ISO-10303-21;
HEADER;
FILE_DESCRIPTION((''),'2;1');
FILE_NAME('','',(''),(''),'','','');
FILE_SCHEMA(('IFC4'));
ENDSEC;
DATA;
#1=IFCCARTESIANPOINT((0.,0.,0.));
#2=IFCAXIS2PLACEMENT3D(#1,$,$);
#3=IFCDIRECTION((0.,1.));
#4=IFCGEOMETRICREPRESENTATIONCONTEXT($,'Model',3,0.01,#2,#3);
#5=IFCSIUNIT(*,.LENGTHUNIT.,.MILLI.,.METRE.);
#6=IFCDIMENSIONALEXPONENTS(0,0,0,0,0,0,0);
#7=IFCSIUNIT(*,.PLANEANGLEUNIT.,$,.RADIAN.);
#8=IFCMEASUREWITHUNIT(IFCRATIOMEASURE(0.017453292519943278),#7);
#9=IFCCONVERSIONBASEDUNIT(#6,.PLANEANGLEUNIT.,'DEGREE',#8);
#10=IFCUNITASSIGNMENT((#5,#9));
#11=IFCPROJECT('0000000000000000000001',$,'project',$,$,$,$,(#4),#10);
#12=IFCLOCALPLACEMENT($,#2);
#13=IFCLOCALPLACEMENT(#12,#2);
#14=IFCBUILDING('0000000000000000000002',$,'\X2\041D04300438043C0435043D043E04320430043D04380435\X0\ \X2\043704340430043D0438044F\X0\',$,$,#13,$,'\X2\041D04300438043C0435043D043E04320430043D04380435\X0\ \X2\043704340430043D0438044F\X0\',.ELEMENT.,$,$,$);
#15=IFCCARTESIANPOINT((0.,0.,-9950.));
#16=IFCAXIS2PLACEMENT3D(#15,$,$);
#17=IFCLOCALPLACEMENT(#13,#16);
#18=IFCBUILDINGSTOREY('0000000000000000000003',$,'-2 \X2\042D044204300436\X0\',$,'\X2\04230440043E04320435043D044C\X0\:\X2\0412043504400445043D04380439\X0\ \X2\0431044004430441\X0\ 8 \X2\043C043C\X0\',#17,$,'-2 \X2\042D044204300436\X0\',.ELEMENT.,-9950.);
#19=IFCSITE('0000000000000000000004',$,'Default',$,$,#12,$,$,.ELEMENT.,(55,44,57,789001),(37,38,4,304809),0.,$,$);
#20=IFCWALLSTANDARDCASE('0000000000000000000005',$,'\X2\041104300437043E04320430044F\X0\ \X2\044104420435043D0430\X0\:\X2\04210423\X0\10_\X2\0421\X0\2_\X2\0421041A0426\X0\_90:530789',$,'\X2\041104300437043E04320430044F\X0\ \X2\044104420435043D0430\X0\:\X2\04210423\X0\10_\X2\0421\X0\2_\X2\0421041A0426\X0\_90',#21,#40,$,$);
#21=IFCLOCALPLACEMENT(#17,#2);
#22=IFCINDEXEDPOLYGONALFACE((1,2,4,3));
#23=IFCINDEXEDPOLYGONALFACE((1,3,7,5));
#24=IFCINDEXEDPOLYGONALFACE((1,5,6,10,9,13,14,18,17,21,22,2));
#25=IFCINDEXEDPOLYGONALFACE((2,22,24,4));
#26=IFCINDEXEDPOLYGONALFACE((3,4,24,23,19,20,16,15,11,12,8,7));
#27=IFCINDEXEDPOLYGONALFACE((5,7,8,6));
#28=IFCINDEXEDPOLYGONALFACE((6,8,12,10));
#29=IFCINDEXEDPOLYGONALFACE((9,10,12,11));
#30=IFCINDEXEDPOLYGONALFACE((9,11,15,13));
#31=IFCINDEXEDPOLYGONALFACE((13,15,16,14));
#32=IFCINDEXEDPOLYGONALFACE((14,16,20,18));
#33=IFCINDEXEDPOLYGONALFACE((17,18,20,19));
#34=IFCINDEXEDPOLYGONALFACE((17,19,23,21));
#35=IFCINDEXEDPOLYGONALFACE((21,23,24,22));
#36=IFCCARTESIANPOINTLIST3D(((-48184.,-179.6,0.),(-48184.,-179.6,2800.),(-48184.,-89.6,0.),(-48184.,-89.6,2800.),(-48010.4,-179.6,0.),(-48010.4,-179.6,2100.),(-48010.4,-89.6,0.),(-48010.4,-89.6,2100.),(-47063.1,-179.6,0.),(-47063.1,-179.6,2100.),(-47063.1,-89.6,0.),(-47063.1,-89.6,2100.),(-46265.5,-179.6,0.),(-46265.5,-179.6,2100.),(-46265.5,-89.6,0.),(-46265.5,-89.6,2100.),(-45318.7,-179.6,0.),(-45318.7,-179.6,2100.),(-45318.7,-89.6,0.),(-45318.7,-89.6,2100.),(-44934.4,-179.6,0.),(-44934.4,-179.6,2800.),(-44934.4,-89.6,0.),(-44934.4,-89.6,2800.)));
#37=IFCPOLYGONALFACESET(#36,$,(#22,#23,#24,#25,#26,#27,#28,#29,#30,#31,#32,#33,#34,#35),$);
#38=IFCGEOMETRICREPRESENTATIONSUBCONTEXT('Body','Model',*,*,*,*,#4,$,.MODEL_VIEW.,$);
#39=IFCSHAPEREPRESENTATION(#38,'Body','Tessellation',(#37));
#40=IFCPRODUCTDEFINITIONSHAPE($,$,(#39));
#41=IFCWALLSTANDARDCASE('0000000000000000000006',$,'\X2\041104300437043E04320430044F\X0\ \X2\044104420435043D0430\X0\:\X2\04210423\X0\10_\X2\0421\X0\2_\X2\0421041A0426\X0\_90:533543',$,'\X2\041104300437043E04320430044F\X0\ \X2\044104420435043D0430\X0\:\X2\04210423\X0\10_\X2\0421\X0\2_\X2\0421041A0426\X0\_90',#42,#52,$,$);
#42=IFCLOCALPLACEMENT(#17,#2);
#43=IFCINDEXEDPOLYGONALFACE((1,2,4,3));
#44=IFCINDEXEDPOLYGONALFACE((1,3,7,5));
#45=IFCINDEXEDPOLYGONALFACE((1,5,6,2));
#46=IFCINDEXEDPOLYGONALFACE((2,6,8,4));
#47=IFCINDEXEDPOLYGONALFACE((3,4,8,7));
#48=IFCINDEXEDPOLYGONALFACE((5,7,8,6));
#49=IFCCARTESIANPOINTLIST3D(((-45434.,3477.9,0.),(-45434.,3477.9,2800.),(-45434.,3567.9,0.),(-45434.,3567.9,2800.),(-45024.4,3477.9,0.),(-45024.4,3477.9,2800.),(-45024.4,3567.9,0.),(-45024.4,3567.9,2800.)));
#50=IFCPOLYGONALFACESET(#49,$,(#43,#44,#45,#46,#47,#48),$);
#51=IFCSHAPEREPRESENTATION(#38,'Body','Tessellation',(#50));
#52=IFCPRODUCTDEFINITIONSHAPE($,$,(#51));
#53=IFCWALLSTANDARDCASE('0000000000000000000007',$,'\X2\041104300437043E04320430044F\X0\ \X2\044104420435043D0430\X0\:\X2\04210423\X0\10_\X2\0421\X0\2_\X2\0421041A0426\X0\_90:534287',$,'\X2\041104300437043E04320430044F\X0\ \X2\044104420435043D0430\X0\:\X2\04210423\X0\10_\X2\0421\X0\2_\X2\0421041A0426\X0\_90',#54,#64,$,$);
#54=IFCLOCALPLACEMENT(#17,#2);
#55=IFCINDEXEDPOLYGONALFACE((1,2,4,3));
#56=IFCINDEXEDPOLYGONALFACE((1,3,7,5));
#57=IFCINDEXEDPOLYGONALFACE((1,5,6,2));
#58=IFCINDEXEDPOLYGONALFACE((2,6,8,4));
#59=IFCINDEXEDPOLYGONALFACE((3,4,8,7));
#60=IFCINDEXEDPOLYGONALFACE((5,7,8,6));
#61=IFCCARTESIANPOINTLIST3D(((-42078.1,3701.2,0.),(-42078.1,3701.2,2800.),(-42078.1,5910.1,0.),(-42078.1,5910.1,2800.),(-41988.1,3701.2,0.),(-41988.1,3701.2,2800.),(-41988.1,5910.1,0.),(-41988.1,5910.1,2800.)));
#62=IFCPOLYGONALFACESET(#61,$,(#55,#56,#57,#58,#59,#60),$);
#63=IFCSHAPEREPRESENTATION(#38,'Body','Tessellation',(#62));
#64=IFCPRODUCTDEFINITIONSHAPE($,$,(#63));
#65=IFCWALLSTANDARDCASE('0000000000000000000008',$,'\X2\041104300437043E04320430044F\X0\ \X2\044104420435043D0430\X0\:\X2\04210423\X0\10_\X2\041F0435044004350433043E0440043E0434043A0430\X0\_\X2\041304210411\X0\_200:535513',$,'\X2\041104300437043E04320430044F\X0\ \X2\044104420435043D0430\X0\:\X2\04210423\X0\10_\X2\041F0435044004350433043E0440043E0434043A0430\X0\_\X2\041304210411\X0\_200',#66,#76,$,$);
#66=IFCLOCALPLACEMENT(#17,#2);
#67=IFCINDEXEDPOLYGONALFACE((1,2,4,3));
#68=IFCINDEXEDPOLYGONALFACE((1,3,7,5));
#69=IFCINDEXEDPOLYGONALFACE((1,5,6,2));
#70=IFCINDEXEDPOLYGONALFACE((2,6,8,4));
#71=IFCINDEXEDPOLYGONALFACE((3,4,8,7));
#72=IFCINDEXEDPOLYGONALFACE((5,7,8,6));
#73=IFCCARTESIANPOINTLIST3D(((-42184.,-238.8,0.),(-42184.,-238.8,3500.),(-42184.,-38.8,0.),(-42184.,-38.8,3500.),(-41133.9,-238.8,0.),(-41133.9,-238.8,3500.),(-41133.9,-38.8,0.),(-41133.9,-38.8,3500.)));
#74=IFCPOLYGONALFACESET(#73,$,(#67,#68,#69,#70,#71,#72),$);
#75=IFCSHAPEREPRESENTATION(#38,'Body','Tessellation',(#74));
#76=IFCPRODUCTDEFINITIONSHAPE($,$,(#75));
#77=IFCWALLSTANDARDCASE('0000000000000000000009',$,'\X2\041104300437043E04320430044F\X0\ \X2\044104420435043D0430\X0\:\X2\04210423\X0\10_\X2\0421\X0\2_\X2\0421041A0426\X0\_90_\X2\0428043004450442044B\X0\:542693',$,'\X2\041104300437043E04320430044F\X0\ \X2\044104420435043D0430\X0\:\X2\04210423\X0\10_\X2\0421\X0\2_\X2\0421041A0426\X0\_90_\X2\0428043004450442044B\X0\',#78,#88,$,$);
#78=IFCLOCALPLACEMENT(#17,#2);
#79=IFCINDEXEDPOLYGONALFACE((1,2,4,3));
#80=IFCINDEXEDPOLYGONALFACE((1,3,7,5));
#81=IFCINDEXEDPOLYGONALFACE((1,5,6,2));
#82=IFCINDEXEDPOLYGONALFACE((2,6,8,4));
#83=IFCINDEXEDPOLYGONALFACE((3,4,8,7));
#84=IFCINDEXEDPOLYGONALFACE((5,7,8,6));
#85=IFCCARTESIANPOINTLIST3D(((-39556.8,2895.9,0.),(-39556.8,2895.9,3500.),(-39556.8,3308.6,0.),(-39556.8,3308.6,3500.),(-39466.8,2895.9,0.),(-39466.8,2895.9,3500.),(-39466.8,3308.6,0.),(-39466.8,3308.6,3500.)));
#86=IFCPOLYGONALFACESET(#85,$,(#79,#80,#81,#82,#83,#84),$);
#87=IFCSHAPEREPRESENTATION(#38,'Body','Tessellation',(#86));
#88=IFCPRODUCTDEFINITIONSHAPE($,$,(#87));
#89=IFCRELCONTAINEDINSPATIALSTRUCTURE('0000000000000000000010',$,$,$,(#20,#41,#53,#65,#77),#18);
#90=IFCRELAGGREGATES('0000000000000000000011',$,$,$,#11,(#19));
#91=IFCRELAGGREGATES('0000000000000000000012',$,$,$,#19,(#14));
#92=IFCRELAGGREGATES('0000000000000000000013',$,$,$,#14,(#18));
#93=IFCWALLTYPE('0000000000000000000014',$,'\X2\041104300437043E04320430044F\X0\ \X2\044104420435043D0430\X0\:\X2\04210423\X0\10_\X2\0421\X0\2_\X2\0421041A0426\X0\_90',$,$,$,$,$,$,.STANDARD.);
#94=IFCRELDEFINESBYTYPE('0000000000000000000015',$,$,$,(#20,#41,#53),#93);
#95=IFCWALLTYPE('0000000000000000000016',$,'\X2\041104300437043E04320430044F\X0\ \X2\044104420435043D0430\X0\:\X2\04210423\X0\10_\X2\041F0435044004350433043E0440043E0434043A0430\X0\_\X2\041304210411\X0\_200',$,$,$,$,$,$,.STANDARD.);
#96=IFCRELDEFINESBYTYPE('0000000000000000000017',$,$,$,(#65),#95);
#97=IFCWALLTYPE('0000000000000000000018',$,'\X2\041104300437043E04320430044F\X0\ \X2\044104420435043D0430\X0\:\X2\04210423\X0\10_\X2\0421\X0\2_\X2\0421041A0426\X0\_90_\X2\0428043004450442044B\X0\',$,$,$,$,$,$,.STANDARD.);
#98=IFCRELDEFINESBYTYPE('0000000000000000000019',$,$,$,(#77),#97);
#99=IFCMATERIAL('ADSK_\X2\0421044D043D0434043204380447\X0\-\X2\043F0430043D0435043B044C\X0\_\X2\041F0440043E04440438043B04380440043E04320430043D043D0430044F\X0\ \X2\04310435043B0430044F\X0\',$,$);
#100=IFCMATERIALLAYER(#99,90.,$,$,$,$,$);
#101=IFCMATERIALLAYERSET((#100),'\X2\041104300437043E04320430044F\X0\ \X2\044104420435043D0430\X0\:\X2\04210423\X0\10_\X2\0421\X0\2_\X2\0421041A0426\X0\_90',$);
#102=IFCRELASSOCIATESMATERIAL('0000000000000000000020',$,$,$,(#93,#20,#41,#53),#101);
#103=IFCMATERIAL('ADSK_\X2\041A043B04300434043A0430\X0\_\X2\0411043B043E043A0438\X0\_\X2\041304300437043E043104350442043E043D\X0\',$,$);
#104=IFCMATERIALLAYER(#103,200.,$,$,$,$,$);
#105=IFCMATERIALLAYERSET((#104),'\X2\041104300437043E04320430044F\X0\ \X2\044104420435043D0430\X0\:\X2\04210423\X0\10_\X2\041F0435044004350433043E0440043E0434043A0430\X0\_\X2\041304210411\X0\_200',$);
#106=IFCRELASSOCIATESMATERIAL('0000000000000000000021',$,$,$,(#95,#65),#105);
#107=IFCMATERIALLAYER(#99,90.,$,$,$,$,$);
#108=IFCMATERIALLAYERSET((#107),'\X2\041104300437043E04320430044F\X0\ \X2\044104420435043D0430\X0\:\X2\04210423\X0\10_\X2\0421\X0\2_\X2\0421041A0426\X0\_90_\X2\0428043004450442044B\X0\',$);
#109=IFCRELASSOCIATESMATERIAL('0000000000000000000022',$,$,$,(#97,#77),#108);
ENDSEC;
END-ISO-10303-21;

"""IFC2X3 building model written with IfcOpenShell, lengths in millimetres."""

from ifc_helpers import new_model, entity, si_unit, converted_unit, direction, frame, frame_2d, origin, place, context, subcontext, project, spatial, rectangle, extrude, material, layer, layer_set, layer_usage, type_object, element, save


model = new_model("IFC2X3")

# Units and contexts
model_context = context("Model", 3, precision=0.01, world=origin(), true_north=direction((0.0, 1.0)))
body_context = subcontext(model_context, "Body", "Model", "MODEL_VIEW")
ifc_project = project(units=[si_unit("LENGTHUNIT", "METRE", prefix="MILLI"), converted_unit("PLANEANGLEUNIT", "DEGREE", entity("IfcRatioMeasure", 0.017453292519943278), si_unit("PLANEANGLEUNIT", "RADIAN"), dimensions=[0, 0, 0, 0, 0, 0, 0])], contexts=[model_context])

# Site, building, storey
site_placement = place(None, origin())
site = spatial("IfcSite", under=ifc_project, at=site_placement, Name="Default", CompositionType="ELEMENT", RefLatitude=(55, 44, 57, 789001), RefLongitude=(37, 38, 4, 304809), RefElevation=0.0)
building_placement = place(site_placement, origin())
building = spatial("IfcBuilding", under=site, at=building_placement, Name="Наименование здания", LongName="Наименование здания", CompositionType="ELEMENT")
storey_placement = place(building_placement, frame((0.0, 0.0, -9950.0)))
storey = spatial("IfcBuildingStorey", under=building, at=storey_placement, Name="-2 Этаж", ObjectType="Уровень:Верхний брус 8 мм", LongName="-2 Этаж", CompositionType="ELEMENT", Elevation=-9950.0)

# Shared definitions
ifc_material_1 = material(Name="ADSK_Сэндвич-панель_Профилированная белая")
ifc_layer_1 = layer(ifc_material_1, 90.0)
ifc_layer_set_1 = layer_set([ifc_layer_1], Name="Базовая стена:СУ10_С2_СКЦ_90")
ifc_layer_usage_1 = layer_usage(ifc_layer_set_1, "AXIS2", "NEGATIVE", 45.0)
wall_type_1 = type_object("IfcWallType", Name="Базовая стена:СУ10_С2_СКЦ_90", PredefinedType="STANDARD", material=ifc_layer_set_1)

# Wall, openings
wall_1_placement = place(storey_placement, frame((-44934.4, -134.6, 0.0), z_axis=(0.0, 0.0, 1.0), x_axis=(-1.0, 0.0, 0.0)))
wall_1 = element("IfcWallStandardCase", 1, at=wall_1_placement, inside=storey, type_object=wall_type_1, material=ifc_layer_usage_1, Name="Базовая стена:СУ10_С2_СКЦ_90:530789", ObjectType="Базовая стена:СУ10_С2_СКЦ_90", context=body_context, shape_type="SweptSolid", body=[
    extrude(rectangle(XDim=3249.6, YDim=90.0, at=frame_2d((1624.8, 0.0), x_axis=(1.0, 0.0))), origin(), (0.0, 0.0, 1.0), 2800.0),
])
opening_1_placement = place(wall_1_placement, origin())
element("IfcOpeningElement", 2, at=opening_1_placement, cuts=wall_1, ObjectType="Opening", context=body_context, shape_type="SweptSolid", body=[
    extrude(rectangle(XDim=2100.0, YDim=947.3, at=frame_2d((0.0, 0.0), x_axis=(1.0, 0.0))), frame((2602.4, -45.0, 1050.0), z_axis=(0.0, 1.0, 0.0), x_axis=(0.0, 0.0, -1.0)), (0.0, 0.0, 1.0), 90.0),
])
opening_2_placement = place(wall_1_placement, origin())
element("IfcOpeningElement", 3, at=opening_2_placement, cuts=wall_1, ObjectType="Opening", context=body_context, shape_type="SweptSolid", body=[
    extrude(rectangle(XDim=2100.0, YDim=946.8, at=frame_2d((0.0, 0.0), x_axis=(1.0, 0.0))), frame((857.7, -45.0, 1050.0), z_axis=(0.0, 1.0, 0.0), x_axis=(0.0, 0.0, -1.0)), (0.0, 0.0, 1.0), 90.0),
])

# Walls
wall_2_placement = place(storey_placement, frame((-45024.4, 3522.9, 0.0), z_axis=(0.0, 0.0, 1.0), x_axis=(-1.0, 0.0, 0.0)))
element("IfcWallStandardCase", 4, at=wall_2_placement, inside=storey, type_object=wall_type_1, material=ifc_layer_usage_1, Name="Базовая стена:СУ10_С2_СКЦ_90:533543", ObjectType="Базовая стена:СУ10_С2_СКЦ_90", context=body_context, shape_type="SweptSolid", body=[
    extrude(rectangle(XDim=409.6, YDim=90.0, at=frame_2d((204.8, 0.0), x_axis=(-1.0, 0.0))), origin(), (0.0, 0.0, 1.0), 2800.0),
])
wall_3_placement = place(storey_placement, frame((-42033.1, 5910.1, 0.0), z_axis=(0.0, 0.0, 1.0), x_axis=(0.0, -1.0, 0.0)))
element("IfcWallStandardCase", 5, at=wall_3_placement, inside=storey, type_object=wall_type_1, material=ifc_layer_usage_1, Name="Базовая стена:СУ10_С2_СКЦ_90:534287", ObjectType="Базовая стена:СУ10_С2_СКЦ_90", context=body_context, shape_type="SweptSolid", body=[
    extrude(rectangle(XDim=2208.9, YDim=90.0, at=frame_2d((1104.4, 0.0), x_axis=(-1.0, 0.0))), origin(), (0.0, 0.0, 1.0), 2800.0),
])
ifc_material_2 = material(Name="ADSK_Кладка_Блоки_Газобетон")
ifc_layer_2 = layer(ifc_material_2, 200.0)
ifc_layer_set_2 = layer_set([ifc_layer_2], Name="Базовая стена:СУ10_Перегородка_ГСБ_200")
ifc_layer_usage_2 = layer_usage(ifc_layer_set_2, "AXIS2", "NEGATIVE", 100.0)
wall_type_2 = type_object("IfcWallType", Name="Базовая стена:СУ10_Перегородка_ГСБ_200", PredefinedType="STANDARD", material=ifc_layer_set_2)
wall_4_placement = place(storey_placement, frame((-41133.9, -138.8, 0.0), z_axis=(0.0, 0.0, 1.0), x_axis=(-1.0, 0.0, 0.0)))
element("IfcWallStandardCase", 6, at=wall_4_placement, inside=storey, type_object=wall_type_2, material=ifc_layer_usage_2, Name="Базовая стена:СУ10_Перегородка_ГСБ_200:535513", ObjectType="Базовая стена:СУ10_Перегородка_ГСБ_200", context=body_context, shape_type="SweptSolid", body=[
    extrude(rectangle(XDim=1050.0, YDim=200.0, at=frame_2d((525.0, 0.0), x_axis=(-1.0, 0.0))), origin(), (0.0, 0.0, 1.0), 3500.0),
])
ifc_layer_3 = layer(ifc_material_1, 90.0)
ifc_layer_set_3 = layer_set([ifc_layer_3], Name="Базовая стена:СУ10_С2_СКЦ_90_Шахты")
ifc_layer_usage_3 = layer_usage(ifc_layer_set_3, "AXIS2", "NEGATIVE", 45.0)
wall_type_3 = type_object("IfcWallType", Name="Базовая стена:СУ10_С2_СКЦ_90_Шахты", PredefinedType="STANDARD", material=ifc_layer_set_3)
wall_5_placement = place(storey_placement, frame((-39511.8, 2895.9, 0.0), z_axis=(0.0, 0.0, 1.0), x_axis=(0.0, 1.0, 0.0)))
element("IfcWallStandardCase", 7, at=wall_5_placement, inside=storey, type_object=wall_type_3, material=ifc_layer_usage_3, Name="Базовая стена:СУ10_С2_СКЦ_90_Шахты:542693", ObjectType="Базовая стена:СУ10_С2_СКЦ_90_Шахты", context=body_context, shape_type="SweptSolid", body=[
    extrude(rectangle(XDim=412.7, YDim=90.0, at=frame_2d((206.3, 0.0), x_axis=(-1.0, 0.0))), origin(), (0.0, 0.0, 1.0), 3500.0),
])

save(model, "model.ifc")
